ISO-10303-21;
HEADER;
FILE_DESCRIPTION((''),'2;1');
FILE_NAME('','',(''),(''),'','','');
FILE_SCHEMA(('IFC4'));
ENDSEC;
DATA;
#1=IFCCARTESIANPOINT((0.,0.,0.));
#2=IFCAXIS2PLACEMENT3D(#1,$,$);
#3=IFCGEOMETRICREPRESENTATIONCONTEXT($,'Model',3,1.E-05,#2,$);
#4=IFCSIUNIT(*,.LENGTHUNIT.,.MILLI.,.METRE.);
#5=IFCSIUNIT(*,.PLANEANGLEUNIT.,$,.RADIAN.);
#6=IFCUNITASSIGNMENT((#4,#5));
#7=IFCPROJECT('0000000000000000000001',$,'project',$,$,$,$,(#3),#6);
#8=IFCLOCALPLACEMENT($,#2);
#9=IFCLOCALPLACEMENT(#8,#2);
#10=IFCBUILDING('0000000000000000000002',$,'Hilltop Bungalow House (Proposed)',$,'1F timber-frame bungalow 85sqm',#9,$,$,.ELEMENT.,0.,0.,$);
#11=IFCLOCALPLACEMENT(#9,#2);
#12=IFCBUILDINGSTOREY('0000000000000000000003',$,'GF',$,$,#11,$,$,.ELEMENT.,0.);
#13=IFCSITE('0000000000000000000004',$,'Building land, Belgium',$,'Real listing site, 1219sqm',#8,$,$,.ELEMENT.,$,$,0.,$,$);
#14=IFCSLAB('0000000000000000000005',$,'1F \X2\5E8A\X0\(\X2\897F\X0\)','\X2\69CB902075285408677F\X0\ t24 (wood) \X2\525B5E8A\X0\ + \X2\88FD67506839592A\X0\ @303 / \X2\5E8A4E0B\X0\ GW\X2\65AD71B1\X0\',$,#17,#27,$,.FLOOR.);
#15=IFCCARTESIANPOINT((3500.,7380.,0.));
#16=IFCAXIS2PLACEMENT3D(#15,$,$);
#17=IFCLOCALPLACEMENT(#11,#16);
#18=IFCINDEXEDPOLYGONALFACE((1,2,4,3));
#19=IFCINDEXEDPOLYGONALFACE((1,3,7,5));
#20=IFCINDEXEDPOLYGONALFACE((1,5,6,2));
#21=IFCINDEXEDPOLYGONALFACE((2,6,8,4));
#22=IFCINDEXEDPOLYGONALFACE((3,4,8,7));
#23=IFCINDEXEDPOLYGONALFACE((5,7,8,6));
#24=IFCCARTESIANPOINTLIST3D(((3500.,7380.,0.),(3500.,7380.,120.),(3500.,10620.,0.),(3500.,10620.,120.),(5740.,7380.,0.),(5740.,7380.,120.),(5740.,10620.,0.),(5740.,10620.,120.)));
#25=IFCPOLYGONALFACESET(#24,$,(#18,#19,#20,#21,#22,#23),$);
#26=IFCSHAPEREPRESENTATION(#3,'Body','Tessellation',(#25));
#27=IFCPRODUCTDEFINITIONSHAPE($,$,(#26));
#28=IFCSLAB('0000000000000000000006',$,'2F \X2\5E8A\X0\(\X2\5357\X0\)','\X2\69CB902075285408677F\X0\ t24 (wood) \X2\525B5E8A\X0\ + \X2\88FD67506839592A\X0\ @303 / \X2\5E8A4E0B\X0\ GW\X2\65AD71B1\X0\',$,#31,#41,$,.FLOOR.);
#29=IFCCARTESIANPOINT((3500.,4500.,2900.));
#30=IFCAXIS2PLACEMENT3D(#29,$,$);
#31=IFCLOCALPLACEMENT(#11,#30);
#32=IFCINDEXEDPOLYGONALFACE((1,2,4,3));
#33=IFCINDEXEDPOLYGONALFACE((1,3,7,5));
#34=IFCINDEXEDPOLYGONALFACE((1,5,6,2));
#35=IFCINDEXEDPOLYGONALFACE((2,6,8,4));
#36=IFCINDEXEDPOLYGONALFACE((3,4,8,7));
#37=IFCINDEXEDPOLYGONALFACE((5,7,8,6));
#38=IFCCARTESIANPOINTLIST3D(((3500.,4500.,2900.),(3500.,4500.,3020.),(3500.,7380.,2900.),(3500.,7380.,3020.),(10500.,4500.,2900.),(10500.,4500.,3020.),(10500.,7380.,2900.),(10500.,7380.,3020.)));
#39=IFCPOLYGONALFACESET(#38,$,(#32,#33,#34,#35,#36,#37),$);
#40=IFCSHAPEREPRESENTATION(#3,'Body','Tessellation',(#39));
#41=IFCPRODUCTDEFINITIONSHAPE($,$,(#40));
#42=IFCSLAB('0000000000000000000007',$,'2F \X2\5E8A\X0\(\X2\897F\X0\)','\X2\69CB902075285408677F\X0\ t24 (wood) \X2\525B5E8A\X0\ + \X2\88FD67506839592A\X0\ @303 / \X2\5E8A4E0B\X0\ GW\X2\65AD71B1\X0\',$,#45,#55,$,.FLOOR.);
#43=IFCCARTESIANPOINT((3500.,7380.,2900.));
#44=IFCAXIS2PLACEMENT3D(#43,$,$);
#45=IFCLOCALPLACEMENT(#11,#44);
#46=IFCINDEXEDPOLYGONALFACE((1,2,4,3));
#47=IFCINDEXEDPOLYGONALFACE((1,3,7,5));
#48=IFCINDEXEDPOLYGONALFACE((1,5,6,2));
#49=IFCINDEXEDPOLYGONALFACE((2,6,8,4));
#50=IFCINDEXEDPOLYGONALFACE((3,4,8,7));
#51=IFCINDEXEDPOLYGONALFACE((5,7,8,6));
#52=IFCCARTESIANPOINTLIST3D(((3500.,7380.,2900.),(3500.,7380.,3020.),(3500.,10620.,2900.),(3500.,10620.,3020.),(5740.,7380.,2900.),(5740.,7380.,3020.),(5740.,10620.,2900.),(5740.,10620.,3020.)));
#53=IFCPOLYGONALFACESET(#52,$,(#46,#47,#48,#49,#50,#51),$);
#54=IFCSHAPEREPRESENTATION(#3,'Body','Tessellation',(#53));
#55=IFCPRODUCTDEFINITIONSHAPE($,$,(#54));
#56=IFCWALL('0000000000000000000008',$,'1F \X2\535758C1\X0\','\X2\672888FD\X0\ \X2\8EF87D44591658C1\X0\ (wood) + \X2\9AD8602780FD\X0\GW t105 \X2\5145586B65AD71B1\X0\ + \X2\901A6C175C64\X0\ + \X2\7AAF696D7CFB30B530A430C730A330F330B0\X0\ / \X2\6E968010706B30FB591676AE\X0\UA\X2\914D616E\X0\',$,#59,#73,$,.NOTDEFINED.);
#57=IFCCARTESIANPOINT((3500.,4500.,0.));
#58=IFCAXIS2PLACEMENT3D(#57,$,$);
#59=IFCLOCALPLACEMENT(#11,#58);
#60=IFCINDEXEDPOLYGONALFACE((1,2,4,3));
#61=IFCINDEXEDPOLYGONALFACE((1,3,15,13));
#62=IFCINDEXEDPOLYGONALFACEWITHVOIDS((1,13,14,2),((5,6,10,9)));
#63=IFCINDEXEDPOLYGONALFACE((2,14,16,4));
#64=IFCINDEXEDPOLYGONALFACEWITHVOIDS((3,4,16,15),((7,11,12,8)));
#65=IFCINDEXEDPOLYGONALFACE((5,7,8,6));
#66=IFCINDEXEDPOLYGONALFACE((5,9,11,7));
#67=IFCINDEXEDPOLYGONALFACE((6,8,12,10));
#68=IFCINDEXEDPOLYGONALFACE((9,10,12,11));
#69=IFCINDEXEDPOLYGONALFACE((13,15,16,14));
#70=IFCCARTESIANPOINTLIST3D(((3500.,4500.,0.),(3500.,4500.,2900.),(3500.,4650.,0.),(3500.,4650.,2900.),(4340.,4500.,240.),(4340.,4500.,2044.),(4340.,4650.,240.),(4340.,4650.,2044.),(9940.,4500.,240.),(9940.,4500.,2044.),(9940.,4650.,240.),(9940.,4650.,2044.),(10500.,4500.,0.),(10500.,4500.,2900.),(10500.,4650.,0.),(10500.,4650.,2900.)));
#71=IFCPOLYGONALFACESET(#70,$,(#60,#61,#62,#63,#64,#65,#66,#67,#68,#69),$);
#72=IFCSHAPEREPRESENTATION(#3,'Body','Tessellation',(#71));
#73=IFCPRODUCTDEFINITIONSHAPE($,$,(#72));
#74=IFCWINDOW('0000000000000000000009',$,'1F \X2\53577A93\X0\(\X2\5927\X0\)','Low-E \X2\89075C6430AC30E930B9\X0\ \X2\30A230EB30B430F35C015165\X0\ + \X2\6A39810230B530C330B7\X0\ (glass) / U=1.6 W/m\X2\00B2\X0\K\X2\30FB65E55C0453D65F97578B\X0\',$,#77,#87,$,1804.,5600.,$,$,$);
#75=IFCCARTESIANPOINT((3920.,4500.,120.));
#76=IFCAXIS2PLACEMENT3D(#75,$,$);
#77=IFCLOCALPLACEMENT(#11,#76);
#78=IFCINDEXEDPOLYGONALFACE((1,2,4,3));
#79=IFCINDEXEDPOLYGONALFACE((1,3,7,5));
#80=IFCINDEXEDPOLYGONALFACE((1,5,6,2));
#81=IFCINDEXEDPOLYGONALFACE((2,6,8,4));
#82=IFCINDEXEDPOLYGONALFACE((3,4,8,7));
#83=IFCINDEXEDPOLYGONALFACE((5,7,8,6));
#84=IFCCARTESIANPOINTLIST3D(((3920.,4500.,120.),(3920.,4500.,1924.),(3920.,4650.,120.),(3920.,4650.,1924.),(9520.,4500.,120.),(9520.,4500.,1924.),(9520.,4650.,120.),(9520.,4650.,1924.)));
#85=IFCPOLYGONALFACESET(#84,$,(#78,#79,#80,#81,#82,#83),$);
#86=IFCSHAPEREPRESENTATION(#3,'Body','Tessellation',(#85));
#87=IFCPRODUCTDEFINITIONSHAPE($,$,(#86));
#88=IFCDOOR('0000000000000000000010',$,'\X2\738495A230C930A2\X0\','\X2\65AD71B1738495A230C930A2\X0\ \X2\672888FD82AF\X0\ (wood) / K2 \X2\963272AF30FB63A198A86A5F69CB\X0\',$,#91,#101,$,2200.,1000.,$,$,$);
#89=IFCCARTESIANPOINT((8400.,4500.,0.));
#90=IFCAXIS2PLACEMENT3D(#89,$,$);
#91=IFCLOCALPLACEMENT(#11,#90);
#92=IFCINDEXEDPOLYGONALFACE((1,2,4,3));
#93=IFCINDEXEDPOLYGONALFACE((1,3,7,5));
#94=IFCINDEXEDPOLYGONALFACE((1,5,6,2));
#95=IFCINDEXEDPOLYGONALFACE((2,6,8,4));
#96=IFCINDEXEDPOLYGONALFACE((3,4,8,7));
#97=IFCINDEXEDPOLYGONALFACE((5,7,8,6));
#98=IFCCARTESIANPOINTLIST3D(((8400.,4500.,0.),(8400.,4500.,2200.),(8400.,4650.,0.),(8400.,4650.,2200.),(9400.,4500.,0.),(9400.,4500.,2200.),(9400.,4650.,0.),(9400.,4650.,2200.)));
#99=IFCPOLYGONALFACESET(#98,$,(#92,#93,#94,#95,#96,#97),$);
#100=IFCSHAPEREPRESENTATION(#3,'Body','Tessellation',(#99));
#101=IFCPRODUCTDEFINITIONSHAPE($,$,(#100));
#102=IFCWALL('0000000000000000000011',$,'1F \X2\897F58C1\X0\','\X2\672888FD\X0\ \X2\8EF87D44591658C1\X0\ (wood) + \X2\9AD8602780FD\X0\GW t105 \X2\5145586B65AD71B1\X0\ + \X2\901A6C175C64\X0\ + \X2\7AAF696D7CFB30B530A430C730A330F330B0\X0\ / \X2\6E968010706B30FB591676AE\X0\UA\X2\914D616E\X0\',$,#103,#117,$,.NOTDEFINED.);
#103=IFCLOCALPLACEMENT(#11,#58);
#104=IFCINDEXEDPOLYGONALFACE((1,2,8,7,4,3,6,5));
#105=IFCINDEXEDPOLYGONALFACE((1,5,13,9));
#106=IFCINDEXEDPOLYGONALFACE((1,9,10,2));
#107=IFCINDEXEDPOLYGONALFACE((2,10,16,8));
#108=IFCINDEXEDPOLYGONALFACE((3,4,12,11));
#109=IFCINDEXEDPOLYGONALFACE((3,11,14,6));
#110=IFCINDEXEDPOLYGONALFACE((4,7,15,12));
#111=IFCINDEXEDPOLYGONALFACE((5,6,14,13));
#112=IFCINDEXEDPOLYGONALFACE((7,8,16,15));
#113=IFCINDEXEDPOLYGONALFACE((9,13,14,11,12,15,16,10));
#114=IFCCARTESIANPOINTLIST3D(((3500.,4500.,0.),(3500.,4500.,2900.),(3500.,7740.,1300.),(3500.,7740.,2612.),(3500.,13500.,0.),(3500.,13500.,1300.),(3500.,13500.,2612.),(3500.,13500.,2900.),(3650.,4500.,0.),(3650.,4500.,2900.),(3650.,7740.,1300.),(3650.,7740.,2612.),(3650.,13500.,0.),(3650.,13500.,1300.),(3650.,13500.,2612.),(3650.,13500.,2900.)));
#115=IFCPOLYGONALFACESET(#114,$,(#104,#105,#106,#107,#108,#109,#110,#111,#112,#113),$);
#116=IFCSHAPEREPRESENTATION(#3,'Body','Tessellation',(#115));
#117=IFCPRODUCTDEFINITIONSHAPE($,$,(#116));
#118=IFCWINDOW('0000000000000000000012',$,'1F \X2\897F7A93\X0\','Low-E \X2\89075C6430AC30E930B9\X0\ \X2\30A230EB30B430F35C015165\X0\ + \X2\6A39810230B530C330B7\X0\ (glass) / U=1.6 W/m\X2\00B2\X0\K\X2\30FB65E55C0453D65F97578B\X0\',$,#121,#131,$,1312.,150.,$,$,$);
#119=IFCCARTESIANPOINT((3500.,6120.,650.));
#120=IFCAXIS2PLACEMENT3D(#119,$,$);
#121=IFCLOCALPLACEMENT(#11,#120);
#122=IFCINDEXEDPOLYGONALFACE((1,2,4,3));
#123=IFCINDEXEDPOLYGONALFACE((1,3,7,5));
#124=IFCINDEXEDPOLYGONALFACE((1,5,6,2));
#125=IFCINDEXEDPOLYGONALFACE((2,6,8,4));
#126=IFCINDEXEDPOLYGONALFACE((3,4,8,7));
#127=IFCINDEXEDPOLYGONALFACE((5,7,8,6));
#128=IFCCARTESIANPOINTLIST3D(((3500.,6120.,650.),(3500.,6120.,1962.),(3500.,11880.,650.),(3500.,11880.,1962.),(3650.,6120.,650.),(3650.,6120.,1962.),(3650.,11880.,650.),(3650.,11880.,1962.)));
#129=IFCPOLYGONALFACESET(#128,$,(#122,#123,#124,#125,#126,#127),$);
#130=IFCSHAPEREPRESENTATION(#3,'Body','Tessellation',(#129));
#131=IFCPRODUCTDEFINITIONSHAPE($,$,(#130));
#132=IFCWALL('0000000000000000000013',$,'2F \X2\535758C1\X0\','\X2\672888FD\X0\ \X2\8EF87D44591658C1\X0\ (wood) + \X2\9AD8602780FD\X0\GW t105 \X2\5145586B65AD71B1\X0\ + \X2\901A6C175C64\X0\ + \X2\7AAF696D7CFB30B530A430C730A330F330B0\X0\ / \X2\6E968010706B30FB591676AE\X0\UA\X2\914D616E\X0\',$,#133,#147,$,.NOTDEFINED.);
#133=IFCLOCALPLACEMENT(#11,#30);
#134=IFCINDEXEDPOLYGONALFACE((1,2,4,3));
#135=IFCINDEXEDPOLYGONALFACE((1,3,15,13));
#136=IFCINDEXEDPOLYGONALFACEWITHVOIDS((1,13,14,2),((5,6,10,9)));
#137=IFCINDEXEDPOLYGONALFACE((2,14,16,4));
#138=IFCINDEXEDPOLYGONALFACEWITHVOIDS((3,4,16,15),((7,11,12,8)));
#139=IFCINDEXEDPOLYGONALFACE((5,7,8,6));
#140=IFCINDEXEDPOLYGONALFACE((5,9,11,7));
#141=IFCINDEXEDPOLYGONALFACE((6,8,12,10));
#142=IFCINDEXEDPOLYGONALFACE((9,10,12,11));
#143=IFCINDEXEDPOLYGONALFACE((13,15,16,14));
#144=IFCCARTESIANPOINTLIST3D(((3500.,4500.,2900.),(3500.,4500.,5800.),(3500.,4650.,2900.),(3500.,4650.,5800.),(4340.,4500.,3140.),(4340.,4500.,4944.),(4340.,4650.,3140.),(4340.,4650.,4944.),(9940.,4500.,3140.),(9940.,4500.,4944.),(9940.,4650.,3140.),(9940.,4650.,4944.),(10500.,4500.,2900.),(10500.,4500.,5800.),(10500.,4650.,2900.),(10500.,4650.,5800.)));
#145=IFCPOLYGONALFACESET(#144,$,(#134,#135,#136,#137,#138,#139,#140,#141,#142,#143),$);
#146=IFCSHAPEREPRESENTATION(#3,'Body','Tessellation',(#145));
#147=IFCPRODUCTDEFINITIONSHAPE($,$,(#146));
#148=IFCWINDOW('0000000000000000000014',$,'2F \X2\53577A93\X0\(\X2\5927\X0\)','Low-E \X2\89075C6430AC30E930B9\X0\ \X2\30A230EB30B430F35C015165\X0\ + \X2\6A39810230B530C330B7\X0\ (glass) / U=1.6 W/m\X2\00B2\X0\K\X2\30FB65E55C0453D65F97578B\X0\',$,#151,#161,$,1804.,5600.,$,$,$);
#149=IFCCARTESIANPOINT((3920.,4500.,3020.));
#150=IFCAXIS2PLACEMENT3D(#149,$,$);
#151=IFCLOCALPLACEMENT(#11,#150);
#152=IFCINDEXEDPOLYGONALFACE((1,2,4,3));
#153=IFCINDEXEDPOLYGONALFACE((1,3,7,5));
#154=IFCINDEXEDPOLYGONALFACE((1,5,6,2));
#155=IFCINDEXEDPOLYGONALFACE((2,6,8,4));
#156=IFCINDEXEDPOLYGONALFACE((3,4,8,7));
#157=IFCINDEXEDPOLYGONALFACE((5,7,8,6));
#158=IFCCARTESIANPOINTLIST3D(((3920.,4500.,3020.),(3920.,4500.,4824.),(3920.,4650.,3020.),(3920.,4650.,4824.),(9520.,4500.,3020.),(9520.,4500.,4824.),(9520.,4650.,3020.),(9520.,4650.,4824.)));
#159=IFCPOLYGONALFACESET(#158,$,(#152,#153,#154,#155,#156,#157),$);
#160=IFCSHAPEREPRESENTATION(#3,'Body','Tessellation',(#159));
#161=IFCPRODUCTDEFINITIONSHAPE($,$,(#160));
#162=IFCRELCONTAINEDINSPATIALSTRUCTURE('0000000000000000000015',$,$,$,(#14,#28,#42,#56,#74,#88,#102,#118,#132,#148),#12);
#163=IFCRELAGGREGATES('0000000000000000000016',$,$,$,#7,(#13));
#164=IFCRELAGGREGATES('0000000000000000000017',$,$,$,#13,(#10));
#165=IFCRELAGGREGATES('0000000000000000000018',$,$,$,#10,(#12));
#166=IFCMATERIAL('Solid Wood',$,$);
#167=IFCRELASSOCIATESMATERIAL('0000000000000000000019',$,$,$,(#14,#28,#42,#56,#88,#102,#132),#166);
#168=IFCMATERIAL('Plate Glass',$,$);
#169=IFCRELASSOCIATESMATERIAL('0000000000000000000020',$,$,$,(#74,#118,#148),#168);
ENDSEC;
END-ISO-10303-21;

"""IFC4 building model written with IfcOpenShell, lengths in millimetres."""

from ifc_helpers import new_model, si_unit, frame, frame_2d, origin, place, context, project, spatial, rectangle, extrude, material, element, fill, save


model = new_model("IFC4")

# Units and contexts
model_context = context("Model", 3, precision=1e-05, world=origin())
ifc_project = project(units=[si_unit("LENGTHUNIT", "METRE", prefix="MILLI"), si_unit("PLANEANGLEUNIT", "RADIAN")], contexts=[model_context])

# Site, building, storey
site_placement = place(None, origin())
site = spatial("IfcSite", under=ifc_project, at=site_placement, Name="Building land, Belgium", ObjectType="Real listing site, 1219sqm", CompositionType="ELEMENT", RefElevation=0.0)
building_placement = place(site_placement, origin())
building = spatial("IfcBuilding", under=site, at=building_placement, Name="Hilltop Bungalow House (Proposed)", ObjectType="1F timber-frame bungalow 85sqm", CompositionType="ELEMENT", ElevationOfRefHeight=0.0, ElevationOfTerrain=0.0)
storey_placement = place(building_placement, origin())
storey = spatial("IfcBuildingStorey", under=building, at=storey_placement, Name="GF", CompositionType="ELEMENT", Elevation=0.0)

# Slabs
ifc_material_1 = material(Name="Solid Wood")
slab_1_placement = place(storey_placement, frame((3500.0, 7380.0, 0.0)))
element("IfcSlab", 1, at=slab_1_placement, inside=storey, material=ifc_material_1, Name="1F 床(西)", Description="構造用合板 t24 (wood) 剛床 + 製材根太 @303 / 床下 GW断熱", PredefinedType="FLOOR", context=model_context, shape_type="SweptSolid", body=[
    extrude(rectangle(XDim=2240.0, YDim=3240.0, at=frame_2d((1120.0, 1620.0))), frame((3500.0, 7380.0, 0.0)), (0.0, 0.0, 1.0), 120.0),
])
slab_2_placement = place(storey_placement, frame((3500.0, 4500.0, 2900.0)))
element("IfcSlab", 2, at=slab_2_placement, inside=storey, material=ifc_material_1, Name="2F 床(南)", Description="構造用合板 t24 (wood) 剛床 + 製材根太 @303 / 床下 GW断熱", PredefinedType="FLOOR", context=model_context, shape_type="SweptSolid", body=[
    extrude(rectangle(XDim=7000.0, YDim=2880.0, at=frame_2d((3500.0, 1440.0))), frame((3500.0, 4500.0, 2900.0)), (0.0, 0.0, 1.0), 120.0),
])
slab_3_placement = place(storey_placement, frame((3500.0, 7380.0, 2900.0)))
element("IfcSlab", 3, at=slab_3_placement, inside=storey, material=ifc_material_1, Name="2F 床(西)", Description="構造用合板 t24 (wood) 剛床 + 製材根太 @303 / 床下 GW断熱", PredefinedType="FLOOR", context=model_context, shape_type="SweptSolid", body=[
    extrude(rectangle(XDim=2240.0, YDim=3240.0, at=frame_2d((1120.0, 1620.0))), frame((3500.0, 7380.0, 2900.0)), (0.0, 0.0, 1.0), 120.0),
])

# Wall, openings, window, door
wall_1_placement = place(storey_placement, frame((3500.0, 4500.0, 0.0)))
wall_1 = element("IfcWall", 4, at=wall_1_placement, inside=storey, material=ifc_material_1, Name="1F 南壁", Description="木製 軸組外壁 (wood) + 高性能GW t105 充填断熱 + 通気層 + 窯業系サイディング / 準耐火・外皮UA配慮", PredefinedType="NOTDEFINED", context=model_context, shape_type="SweptSolid", body=[
    extrude(rectangle(XDim=7000.0, YDim=150.0, at=frame_2d((3500.0, 75.0))), frame((3500.0, 4500.0, 0.0)), (0.0, 0.0, 1.0), 2900.0),
])
opening_1_placement = place(storey_placement, frame((3920.0, 4500.0, 120.0)))
opening_1 = element("IfcOpeningElement", 5, at=opening_1_placement, cuts=wall_1, PredefinedType="NOTDEFINED", context=model_context, shape_type="SweptSolid", body=[
    extrude(rectangle(XDim=5600.0, YDim=150.0, at=frame_2d((2800.0, 75.0))), frame((3920.0, 4500.0, 120.0)), (0.0, 0.0, 1.0), 1804.0),
])
opening_2_placement = place(storey_placement, frame((8400.0, 4500.0, 0.0)))
opening_2 = element("IfcOpeningElement", 6, at=opening_2_placement, cuts=wall_1, PredefinedType="NOTDEFINED", context=model_context, shape_type="SweptSolid", body=[
    extrude(rectangle(XDim=1000.0, YDim=150.0, at=frame_2d((500.0, 75.0))), frame((8400.0, 4500.0, 0.0)), (0.0, 0.0, 1.0), 2200.0),
])
ifc_material_2 = material(Name="Plate Glass")
window_1_placement = place(storey_placement, frame((3920.0, 4500.0, 120.0)))
window_1 = element("IfcWindow", 7, at=window_1_placement, inside=storey, material=ifc_material_2, Name="1F 南窓(大)", Description="Low-E 複層ガラス アルゴン封入 + 樹脂サッシ (glass) / U=1.6 W/m²K・日射取得型", OverallHeight=1804.0, OverallWidth=5600.0, context=model_context, shape_type="SweptSolid", body=[
    extrude(rectangle(XDim=5600.0, YDim=150.0, at=frame_2d((2800.0, 75.0))), frame((3920.0, 4500.0, 120.0)), (0.0, 0.0, 1.0), 1804.0),
])
fill(opening_1, window_1)
door_placement = place(storey_placement, frame((8400.0, 4500.0, 0.0)))
door = element("IfcDoor", 8, at=door_placement, inside=storey, material=ifc_material_1, Name="玄関ドア", Description="断熱玄関ドア 木製芯 (wood) / K2 防犯・採風機構", OverallHeight=2200.0, OverallWidth=1000.0, context=model_context, shape_type="SweptSolid", body=[
    extrude(rectangle(XDim=1000.0, YDim=150.0, at=frame_2d((500.0, 75.0))), frame((8400.0, 4500.0, 0.0)), (0.0, 0.0, 1.0), 2200.0),
])
fill(opening_2, door)

# Walls, openings, windows
wall_2_placement = place(storey_placement, frame((3500.0, 4500.0, 0.0)))
wall_2 = element("IfcWall", 9, at=wall_2_placement, inside=storey, material=ifc_material_1, Name="1F 西壁", Description="木製 軸組外壁 (wood) + 高性能GW t105 充填断熱 + 通気層 + 窯業系サイディング / 準耐火・外皮UA配慮", PredefinedType="NOTDEFINED", context=model_context, shape_type="SweptSolid", body=[
    extrude(rectangle(XDim=150.0, YDim=9000.0, at=frame_2d((75.0, 4500.0))), frame((3500.0, 4500.0, 0.0)), (0.0, 0.0, 1.0), 2900.0),
])
opening_3_placement = place(storey_placement, frame((3500.0, 6120.0, 650.0)))
opening_3 = element("IfcOpeningElement", 10, at=opening_3_placement, cuts=wall_2, PredefinedType="NOTDEFINED", context=model_context, shape_type="SweptSolid", body=[
    extrude(rectangle(XDim=150.0, YDim=5760.0, at=frame_2d((75.0, 2880.0))), frame((3500.0, 6120.0, 650.0)), (0.0, 0.0, 1.0), 1312.0),
])
window_2_placement = place(storey_placement, frame((3500.0, 6120.0, 650.0)))
window_2 = element("IfcWindow", 11, at=window_2_placement, inside=storey, material=ifc_material_2, Name="1F 西窓", Description="Low-E 複層ガラス アルゴン封入 + 樹脂サッシ (glass) / U=1.6 W/m²K・日射取得型", OverallHeight=1312.0, OverallWidth=150.0, context=model_context, shape_type="SweptSolid", body=[
    extrude(rectangle(XDim=150.0, YDim=5760.0, at=frame_2d((75.0, 2880.0))), frame((3500.0, 6120.0, 650.0)), (0.0, 0.0, 1.0), 1312.0),
])
fill(opening_3, window_2)
wall_3_placement = place(storey_placement, frame((3500.0, 4500.0, 2900.0)))
wall_3 = element("IfcWall", 12, at=wall_3_placement, inside=storey, material=ifc_material_1, Name="2F 南壁", Description="木製 軸組外壁 (wood) + 高性能GW t105 充填断熱 + 通気層 + 窯業系サイディング / 準耐火・外皮UA配慮", PredefinedType="NOTDEFINED", context=model_context, shape_type="SweptSolid", body=[
    extrude(rectangle(XDim=7000.0, YDim=150.0, at=frame_2d((3500.0, 75.0))), frame((3500.0, 4500.0, 2900.0)), (0.0, 0.0, 1.0), 2900.0),
])
opening_4_placement = place(storey_placement, frame((3920.0, 4500.0, 3020.0)))
opening_4 = element("IfcOpeningElement", 13, at=opening_4_placement, cuts=wall_3, PredefinedType="NOTDEFINED", context=model_context, shape_type="SweptSolid", body=[
    extrude(rectangle(XDim=5600.0, YDim=150.0, at=frame_2d((2800.0, 75.0))), frame((3920.0, 4500.0, 3020.0)), (0.0, 0.0, 1.0), 1804.0),
])
window_3_placement = place(storey_placement, frame((3920.0, 4500.0, 3020.0)))
window_3 = element("IfcWindow", 14, at=window_3_placement, inside=storey, material=ifc_material_2, Name="2F 南窓(大)", Description="Low-E 複層ガラス アルゴン封入 + 樹脂サッシ (glass) / U=1.6 W/m²K・日射取得型", OverallHeight=1804.0, OverallWidth=5600.0, context=model_context, shape_type="SweptSolid", body=[
    extrude(rectangle(XDim=5600.0, YDim=150.0, at=frame_2d((2800.0, 75.0))), frame((3920.0, 4500.0, 3020.0)), (0.0, 0.0, 1.0), 1804.0),
])
fill(opening_4, window_3)

save(model, "model.ifc")
